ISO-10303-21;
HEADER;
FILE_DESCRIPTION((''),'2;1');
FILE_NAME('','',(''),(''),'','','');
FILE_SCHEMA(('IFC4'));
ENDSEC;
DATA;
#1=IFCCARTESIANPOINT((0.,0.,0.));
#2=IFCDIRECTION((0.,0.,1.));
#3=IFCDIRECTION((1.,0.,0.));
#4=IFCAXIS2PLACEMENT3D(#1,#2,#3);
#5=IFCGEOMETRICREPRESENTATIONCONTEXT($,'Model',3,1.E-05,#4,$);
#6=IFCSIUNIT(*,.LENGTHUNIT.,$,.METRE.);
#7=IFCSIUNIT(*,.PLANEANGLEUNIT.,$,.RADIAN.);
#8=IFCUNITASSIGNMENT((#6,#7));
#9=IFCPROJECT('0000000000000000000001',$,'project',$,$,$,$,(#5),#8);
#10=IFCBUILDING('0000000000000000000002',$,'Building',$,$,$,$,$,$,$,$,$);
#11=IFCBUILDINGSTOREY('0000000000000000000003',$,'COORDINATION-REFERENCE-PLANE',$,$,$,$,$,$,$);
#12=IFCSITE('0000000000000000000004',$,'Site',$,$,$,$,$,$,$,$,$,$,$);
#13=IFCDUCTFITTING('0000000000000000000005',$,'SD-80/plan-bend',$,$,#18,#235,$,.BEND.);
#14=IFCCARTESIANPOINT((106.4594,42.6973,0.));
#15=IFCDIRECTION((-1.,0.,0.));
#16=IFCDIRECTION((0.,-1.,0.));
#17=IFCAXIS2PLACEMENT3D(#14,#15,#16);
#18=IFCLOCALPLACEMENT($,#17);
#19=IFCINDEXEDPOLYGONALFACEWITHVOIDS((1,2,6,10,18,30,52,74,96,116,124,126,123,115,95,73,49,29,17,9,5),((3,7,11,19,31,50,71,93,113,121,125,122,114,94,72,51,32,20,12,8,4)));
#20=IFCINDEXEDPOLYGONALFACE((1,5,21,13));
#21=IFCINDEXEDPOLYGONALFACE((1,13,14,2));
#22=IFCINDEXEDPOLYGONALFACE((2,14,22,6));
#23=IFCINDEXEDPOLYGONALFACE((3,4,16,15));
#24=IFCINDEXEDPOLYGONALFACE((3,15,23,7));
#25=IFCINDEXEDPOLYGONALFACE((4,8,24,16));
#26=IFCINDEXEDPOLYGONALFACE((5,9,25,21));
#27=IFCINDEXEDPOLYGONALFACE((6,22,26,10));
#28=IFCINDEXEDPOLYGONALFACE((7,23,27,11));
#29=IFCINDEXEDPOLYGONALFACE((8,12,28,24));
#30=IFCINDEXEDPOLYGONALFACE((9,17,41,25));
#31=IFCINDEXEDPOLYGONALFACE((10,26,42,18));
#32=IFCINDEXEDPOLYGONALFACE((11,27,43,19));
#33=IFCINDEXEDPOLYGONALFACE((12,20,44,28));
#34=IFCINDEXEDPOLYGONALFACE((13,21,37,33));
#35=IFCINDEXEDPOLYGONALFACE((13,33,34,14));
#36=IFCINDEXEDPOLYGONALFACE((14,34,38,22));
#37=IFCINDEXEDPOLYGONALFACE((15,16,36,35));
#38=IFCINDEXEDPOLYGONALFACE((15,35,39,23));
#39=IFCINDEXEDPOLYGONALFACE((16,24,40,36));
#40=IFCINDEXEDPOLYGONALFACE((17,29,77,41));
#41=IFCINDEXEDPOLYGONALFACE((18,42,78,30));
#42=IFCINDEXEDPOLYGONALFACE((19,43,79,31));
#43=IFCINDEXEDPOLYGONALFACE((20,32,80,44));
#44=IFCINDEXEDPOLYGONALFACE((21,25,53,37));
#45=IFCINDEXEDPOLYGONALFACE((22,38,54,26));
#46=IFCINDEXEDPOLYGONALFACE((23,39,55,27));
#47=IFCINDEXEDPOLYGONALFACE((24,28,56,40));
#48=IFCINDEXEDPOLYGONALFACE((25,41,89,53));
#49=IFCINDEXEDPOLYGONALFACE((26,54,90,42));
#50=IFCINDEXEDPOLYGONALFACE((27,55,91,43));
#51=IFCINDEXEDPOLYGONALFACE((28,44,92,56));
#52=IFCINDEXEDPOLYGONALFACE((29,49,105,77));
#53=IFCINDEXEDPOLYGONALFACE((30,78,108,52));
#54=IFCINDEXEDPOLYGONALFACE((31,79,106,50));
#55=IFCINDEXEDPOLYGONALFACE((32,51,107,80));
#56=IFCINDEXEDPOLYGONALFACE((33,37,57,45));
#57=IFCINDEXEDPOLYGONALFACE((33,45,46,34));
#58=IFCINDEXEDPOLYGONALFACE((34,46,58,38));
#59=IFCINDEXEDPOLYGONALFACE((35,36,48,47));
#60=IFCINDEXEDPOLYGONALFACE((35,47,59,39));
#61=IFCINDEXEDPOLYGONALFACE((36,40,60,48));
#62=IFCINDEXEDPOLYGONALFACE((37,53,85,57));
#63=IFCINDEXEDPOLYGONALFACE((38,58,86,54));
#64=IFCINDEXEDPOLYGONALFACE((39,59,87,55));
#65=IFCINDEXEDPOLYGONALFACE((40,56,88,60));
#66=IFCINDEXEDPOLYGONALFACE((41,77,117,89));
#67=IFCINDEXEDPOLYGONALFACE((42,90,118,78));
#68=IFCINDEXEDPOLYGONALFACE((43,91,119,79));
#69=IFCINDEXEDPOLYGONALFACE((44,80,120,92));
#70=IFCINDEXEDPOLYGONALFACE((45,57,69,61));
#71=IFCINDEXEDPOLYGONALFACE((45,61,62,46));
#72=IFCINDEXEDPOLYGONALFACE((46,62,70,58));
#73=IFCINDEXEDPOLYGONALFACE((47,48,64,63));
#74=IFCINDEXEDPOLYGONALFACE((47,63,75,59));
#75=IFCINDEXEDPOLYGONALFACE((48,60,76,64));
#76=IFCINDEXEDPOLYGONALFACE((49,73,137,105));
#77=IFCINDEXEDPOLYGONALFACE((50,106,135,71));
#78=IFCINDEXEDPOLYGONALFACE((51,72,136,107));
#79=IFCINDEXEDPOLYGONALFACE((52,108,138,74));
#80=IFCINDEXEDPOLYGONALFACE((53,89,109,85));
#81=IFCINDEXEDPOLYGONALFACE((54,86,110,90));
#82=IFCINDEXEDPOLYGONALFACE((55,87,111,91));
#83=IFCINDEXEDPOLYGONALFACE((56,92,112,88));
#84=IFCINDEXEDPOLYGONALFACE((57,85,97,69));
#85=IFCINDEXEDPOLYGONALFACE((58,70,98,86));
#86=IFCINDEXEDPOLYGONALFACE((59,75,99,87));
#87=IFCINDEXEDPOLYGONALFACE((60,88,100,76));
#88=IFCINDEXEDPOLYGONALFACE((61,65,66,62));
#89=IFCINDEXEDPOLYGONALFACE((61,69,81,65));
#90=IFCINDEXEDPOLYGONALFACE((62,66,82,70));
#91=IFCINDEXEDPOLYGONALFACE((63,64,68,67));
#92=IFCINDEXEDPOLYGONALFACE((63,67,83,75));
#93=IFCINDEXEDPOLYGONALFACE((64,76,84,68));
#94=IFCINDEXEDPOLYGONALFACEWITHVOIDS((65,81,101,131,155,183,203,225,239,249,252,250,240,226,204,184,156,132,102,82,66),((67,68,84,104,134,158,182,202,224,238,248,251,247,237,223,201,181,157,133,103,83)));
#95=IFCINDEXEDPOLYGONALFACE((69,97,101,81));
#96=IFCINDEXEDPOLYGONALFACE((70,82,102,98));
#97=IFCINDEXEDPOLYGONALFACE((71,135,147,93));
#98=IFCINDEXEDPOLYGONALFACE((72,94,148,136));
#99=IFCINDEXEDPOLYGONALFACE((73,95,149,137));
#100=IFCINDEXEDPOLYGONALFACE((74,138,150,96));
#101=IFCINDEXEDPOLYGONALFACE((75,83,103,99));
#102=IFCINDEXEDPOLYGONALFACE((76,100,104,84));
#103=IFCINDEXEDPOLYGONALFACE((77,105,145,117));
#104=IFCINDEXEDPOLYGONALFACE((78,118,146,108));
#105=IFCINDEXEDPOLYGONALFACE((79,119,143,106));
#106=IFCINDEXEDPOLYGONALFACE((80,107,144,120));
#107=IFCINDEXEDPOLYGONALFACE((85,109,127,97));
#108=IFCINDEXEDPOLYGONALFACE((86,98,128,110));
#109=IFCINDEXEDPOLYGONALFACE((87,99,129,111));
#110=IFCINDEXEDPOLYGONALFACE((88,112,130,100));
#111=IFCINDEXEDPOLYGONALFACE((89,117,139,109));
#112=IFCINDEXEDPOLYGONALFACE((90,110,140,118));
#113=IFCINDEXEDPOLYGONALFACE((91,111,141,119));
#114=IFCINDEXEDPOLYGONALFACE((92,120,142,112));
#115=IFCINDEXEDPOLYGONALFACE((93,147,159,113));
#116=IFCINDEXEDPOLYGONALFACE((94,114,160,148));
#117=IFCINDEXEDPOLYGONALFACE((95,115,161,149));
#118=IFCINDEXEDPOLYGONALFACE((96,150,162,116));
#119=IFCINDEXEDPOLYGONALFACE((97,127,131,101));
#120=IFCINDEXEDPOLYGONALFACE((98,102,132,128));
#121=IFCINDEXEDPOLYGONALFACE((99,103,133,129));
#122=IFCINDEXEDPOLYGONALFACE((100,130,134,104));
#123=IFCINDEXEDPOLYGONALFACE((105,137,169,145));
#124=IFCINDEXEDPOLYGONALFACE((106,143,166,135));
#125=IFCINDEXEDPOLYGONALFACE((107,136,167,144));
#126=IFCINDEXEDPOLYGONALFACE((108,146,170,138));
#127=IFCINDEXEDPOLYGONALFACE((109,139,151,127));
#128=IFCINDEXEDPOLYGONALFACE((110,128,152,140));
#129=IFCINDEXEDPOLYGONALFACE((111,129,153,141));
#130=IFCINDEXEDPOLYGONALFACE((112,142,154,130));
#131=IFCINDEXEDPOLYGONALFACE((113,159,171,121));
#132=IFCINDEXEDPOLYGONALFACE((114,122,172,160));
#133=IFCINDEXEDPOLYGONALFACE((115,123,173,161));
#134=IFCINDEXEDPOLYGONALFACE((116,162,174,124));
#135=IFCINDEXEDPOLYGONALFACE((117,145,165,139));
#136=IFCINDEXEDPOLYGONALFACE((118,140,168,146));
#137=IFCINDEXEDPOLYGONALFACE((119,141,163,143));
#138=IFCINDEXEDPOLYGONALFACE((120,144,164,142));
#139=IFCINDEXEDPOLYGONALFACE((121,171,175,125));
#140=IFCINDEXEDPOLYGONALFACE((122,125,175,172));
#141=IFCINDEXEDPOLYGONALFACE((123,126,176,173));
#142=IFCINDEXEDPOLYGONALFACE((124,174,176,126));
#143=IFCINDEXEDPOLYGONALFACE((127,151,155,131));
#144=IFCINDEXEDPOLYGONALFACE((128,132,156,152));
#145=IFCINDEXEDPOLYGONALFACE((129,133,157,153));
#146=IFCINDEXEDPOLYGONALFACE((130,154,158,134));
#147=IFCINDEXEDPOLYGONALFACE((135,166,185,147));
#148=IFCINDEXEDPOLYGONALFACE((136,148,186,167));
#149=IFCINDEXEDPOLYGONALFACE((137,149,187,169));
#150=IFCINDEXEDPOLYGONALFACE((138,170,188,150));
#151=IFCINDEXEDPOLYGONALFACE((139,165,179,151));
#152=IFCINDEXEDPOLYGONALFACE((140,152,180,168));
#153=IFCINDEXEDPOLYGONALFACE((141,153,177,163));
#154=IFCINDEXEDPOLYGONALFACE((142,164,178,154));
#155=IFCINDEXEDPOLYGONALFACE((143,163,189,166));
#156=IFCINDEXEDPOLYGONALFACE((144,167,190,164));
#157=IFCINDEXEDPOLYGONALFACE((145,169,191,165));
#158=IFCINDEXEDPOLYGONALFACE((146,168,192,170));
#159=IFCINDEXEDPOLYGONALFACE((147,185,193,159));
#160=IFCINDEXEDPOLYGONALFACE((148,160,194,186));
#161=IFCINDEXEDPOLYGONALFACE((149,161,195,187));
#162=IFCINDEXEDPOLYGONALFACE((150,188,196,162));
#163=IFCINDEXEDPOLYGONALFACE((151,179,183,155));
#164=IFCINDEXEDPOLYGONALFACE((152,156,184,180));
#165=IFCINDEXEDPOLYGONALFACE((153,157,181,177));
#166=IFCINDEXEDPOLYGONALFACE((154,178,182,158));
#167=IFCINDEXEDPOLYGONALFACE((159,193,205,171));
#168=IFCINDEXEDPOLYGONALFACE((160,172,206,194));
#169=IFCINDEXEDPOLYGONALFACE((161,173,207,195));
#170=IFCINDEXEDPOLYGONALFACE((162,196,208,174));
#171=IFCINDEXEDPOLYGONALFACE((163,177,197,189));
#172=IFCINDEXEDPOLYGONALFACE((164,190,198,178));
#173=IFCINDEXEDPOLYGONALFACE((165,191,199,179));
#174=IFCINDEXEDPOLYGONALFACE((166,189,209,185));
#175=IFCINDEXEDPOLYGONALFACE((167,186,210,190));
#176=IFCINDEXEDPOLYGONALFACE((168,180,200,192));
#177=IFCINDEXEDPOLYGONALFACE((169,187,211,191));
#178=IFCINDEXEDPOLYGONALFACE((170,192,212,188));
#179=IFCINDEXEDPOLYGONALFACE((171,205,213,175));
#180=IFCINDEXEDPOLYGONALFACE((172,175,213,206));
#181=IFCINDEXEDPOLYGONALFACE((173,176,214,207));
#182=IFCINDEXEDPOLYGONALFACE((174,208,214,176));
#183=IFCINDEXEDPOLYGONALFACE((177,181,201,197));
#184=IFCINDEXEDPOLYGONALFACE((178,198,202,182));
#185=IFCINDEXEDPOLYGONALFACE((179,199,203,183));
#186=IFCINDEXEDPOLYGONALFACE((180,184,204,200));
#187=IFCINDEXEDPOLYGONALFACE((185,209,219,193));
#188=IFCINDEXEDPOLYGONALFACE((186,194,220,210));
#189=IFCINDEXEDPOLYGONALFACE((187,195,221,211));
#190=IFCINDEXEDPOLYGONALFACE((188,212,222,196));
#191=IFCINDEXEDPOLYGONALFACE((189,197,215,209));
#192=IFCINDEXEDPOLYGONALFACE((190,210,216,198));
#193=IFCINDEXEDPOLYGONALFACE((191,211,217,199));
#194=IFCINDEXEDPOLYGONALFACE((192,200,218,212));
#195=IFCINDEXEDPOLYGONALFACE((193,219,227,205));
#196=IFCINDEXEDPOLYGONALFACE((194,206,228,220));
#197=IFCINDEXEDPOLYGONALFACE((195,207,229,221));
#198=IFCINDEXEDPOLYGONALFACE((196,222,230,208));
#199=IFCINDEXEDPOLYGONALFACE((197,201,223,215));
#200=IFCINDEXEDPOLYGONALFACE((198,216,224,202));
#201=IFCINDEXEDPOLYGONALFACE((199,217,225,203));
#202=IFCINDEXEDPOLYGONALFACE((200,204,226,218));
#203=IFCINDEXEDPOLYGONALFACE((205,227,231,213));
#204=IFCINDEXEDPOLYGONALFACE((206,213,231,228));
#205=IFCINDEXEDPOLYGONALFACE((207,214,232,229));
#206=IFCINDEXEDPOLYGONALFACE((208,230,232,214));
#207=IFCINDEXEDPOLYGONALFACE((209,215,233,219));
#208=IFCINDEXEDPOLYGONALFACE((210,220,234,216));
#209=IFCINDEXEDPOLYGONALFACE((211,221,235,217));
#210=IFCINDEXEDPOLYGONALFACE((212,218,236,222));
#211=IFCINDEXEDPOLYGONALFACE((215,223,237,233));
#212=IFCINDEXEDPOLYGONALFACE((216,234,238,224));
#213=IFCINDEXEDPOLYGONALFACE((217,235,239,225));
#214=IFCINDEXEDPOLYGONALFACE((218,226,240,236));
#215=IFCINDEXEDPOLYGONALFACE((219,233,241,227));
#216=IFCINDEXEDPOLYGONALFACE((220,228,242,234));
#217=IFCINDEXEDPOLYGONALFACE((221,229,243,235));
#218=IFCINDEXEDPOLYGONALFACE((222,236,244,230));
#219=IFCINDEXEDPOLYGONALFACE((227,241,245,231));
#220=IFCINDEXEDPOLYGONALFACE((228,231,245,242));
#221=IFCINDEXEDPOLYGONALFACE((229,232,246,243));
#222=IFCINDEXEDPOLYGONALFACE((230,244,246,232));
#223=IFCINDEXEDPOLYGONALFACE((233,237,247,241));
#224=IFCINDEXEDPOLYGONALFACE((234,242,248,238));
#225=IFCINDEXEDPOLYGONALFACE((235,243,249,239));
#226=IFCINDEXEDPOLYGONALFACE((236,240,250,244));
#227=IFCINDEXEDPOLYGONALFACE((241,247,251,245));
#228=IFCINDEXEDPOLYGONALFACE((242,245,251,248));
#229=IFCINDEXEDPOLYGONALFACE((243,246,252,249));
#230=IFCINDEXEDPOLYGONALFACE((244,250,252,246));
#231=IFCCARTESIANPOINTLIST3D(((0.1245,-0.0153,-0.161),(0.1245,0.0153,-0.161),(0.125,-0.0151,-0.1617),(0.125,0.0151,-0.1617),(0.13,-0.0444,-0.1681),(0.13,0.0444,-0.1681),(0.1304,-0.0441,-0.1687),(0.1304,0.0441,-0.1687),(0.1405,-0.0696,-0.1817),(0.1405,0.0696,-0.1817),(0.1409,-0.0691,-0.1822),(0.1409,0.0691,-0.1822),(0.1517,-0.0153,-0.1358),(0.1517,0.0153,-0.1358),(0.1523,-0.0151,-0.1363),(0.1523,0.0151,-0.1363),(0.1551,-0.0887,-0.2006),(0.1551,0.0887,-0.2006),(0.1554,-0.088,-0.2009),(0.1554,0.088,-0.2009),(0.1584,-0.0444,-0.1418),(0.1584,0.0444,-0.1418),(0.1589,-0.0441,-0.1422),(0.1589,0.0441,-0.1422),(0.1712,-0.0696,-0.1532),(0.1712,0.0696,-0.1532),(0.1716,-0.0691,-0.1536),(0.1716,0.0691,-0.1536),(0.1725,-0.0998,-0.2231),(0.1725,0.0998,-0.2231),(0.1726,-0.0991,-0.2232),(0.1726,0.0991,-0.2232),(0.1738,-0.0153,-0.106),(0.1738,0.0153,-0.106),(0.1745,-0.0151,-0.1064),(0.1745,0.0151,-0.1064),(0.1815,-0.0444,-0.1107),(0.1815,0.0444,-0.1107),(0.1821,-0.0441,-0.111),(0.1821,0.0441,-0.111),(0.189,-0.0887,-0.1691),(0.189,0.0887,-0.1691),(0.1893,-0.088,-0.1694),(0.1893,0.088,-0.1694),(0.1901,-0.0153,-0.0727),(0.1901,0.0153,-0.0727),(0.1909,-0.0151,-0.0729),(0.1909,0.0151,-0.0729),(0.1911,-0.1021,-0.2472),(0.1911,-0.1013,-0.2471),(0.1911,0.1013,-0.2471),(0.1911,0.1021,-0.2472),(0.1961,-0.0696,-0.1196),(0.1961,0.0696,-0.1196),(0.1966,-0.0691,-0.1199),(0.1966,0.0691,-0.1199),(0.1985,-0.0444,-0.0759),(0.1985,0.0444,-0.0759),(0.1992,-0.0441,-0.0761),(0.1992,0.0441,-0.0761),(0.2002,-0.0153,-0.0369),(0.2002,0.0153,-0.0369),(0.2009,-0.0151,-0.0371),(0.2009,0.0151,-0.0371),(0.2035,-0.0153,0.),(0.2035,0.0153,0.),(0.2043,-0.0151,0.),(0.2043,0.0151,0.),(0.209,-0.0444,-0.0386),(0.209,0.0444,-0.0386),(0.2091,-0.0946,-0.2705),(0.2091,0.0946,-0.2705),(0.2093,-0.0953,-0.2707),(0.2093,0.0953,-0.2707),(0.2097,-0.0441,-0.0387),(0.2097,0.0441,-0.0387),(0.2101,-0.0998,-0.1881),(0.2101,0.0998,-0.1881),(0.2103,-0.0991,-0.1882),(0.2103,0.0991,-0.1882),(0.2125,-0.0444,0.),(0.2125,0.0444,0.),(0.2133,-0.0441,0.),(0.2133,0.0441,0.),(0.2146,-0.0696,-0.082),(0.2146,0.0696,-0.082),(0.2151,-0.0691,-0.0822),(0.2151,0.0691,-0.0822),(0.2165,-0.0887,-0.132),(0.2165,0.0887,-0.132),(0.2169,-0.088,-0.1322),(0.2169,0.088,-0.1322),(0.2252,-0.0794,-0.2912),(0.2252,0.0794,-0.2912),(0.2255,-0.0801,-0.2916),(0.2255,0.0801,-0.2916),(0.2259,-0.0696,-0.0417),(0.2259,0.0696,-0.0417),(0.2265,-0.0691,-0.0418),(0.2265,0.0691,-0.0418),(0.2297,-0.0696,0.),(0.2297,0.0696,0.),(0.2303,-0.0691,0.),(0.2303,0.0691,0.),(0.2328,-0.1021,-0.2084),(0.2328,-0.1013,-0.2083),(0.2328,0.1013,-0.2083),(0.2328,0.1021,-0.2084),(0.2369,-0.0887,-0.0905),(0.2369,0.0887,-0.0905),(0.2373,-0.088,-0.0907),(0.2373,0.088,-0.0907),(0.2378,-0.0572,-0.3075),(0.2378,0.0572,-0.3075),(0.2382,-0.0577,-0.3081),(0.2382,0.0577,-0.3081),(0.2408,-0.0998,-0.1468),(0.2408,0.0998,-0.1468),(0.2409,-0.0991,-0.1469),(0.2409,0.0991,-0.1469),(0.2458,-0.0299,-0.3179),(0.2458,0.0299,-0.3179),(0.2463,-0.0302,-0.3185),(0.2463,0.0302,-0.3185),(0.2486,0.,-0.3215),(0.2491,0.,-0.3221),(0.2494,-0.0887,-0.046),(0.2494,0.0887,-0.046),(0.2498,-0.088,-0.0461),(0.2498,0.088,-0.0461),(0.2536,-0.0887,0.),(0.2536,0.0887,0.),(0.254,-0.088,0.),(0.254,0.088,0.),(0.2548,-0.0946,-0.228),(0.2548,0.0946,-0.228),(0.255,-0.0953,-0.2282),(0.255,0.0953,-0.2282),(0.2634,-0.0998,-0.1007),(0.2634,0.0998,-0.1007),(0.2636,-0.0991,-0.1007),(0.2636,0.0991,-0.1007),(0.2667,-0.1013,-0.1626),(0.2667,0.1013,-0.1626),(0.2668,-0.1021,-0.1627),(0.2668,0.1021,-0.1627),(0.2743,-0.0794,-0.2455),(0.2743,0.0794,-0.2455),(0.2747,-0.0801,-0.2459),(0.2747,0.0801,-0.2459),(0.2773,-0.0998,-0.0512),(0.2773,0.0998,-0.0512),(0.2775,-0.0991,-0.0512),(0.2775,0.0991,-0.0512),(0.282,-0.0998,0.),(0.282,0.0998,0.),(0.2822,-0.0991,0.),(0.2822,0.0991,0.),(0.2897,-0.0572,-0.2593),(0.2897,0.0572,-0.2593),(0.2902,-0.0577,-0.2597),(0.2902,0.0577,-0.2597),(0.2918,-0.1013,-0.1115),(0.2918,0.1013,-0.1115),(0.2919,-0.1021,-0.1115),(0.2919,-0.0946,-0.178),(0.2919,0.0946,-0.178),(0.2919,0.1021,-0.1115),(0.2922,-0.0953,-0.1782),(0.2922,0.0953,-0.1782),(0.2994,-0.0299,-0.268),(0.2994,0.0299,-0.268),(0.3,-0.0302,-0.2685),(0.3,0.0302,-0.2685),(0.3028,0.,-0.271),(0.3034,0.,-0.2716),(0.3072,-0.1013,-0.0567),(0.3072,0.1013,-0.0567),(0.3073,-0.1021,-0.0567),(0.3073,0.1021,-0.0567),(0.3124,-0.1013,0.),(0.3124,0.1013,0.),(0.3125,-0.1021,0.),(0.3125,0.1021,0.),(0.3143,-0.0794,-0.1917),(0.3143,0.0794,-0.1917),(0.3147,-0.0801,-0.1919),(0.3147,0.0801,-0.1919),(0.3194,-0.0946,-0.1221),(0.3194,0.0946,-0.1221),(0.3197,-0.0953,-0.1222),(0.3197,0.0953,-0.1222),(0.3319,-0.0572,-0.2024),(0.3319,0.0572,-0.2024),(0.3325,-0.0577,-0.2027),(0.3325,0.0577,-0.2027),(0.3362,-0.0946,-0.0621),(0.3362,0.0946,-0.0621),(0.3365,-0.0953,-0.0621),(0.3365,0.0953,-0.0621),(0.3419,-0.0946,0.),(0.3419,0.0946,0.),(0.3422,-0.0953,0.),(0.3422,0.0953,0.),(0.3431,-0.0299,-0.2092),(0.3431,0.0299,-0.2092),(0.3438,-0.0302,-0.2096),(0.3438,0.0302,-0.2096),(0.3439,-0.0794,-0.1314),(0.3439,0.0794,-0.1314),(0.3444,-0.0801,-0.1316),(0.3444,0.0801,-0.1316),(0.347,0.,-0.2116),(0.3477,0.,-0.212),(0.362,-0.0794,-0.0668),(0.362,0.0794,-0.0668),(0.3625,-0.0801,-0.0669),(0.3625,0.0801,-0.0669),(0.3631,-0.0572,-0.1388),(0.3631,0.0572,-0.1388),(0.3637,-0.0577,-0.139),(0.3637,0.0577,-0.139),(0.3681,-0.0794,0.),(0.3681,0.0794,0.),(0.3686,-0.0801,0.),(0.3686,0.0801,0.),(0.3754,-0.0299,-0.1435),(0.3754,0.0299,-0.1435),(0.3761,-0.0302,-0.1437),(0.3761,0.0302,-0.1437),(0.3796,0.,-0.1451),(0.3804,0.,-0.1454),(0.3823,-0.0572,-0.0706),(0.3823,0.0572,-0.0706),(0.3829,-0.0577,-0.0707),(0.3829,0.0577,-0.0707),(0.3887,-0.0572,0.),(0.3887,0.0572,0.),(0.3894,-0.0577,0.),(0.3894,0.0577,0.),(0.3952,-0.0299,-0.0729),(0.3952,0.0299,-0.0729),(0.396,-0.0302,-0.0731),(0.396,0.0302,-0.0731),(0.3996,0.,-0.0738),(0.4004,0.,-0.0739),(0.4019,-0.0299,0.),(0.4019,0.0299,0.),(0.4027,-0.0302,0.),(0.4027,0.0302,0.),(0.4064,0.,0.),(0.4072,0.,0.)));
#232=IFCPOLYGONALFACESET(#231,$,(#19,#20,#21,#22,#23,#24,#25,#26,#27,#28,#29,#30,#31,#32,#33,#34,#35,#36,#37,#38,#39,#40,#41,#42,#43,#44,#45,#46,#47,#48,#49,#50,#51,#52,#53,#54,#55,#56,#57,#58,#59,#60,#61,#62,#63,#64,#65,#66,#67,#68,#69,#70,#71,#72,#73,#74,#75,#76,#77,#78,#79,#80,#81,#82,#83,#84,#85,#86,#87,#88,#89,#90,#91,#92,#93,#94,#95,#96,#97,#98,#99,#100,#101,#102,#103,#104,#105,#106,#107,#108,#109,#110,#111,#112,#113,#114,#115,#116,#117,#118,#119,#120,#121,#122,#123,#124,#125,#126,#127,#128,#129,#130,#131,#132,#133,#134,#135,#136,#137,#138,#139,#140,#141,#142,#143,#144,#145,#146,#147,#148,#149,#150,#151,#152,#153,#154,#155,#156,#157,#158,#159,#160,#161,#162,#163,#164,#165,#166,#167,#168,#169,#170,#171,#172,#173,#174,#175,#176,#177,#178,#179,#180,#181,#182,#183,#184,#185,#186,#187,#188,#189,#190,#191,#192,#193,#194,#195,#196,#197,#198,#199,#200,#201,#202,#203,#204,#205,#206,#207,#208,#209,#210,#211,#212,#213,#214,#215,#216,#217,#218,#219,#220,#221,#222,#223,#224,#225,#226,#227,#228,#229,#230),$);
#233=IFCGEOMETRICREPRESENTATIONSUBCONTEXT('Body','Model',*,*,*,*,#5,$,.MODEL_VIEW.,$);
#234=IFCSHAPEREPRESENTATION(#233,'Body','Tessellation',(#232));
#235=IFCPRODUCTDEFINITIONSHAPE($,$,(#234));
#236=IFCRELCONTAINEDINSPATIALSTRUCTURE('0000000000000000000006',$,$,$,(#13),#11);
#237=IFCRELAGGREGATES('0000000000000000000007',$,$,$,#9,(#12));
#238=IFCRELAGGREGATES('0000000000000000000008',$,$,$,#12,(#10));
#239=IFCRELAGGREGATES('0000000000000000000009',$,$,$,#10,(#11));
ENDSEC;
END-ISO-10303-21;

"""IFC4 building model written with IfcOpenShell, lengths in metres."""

from ifc_helpers import new_model, entity, si_unit, frame, origin_with_axes, place, context, subcontext, project, spatial, element, save


model = new_model("IFC4")

# Units and contexts
model_context_1 = context("Model", 3, precision=1e-05, world=origin_with_axes())
body_context_1 = subcontext(model_context_1, "Body", "Model", "MODEL_VIEW")
ifc_project = project(units=[si_unit("LENGTHUNIT", "METRE"), si_unit("PLANEANGLEUNIT", "RADIAN")], contexts=[model_context_1])

# Site, building, storey
site = spatial("IfcSite", under=ifc_project, Name="Site")
building = spatial("IfcBuilding", under=site, Name="Building")
storey = spatial("IfcBuildingStorey", under=building, Name="COORDINATION-REFERENCE-PLANE")

# Duct fitting
duct_fitting_1_placement = place(None, frame((106.4594, 42.6973, 0.0), z_axis=(-1.0, 0.0, 0.0), x_axis=(0.0, -1.0, 0.0)))
element("IfcDuctFitting", 1, at=duct_fitting_1_placement, inside=storey, Name="SD-80/plan-bend", PredefinedType="BEND", context=body_context_1, shape_type="SweptSolid", body=[
    entity("IfcRevolvedAreaSolid", entity("IfcCircleHollowProfileDef", "AREA", None, entity("IfcAxis2Placement2D", entity("IfcCartesianPoint", [0.3048, 0.0])), 0.1024, 0.0008), entity("IfcAxis2Placement3D", entity("IfcCartesianPoint", [0.0, 0.0, 0.0]), entity("IfcDirection", [0.0, 0.0, 1.0]), entity("IfcDirection", [1.0, 0.0, 0.0])), entity("IfcAxis1Placement", entity("IfcCartesianPoint", [0.0, 0.0, 0.0]), entity("IfcDirection", [0.0, 1.0, 0.0])), 0.912619),
])

save(model, "model.ifc")
